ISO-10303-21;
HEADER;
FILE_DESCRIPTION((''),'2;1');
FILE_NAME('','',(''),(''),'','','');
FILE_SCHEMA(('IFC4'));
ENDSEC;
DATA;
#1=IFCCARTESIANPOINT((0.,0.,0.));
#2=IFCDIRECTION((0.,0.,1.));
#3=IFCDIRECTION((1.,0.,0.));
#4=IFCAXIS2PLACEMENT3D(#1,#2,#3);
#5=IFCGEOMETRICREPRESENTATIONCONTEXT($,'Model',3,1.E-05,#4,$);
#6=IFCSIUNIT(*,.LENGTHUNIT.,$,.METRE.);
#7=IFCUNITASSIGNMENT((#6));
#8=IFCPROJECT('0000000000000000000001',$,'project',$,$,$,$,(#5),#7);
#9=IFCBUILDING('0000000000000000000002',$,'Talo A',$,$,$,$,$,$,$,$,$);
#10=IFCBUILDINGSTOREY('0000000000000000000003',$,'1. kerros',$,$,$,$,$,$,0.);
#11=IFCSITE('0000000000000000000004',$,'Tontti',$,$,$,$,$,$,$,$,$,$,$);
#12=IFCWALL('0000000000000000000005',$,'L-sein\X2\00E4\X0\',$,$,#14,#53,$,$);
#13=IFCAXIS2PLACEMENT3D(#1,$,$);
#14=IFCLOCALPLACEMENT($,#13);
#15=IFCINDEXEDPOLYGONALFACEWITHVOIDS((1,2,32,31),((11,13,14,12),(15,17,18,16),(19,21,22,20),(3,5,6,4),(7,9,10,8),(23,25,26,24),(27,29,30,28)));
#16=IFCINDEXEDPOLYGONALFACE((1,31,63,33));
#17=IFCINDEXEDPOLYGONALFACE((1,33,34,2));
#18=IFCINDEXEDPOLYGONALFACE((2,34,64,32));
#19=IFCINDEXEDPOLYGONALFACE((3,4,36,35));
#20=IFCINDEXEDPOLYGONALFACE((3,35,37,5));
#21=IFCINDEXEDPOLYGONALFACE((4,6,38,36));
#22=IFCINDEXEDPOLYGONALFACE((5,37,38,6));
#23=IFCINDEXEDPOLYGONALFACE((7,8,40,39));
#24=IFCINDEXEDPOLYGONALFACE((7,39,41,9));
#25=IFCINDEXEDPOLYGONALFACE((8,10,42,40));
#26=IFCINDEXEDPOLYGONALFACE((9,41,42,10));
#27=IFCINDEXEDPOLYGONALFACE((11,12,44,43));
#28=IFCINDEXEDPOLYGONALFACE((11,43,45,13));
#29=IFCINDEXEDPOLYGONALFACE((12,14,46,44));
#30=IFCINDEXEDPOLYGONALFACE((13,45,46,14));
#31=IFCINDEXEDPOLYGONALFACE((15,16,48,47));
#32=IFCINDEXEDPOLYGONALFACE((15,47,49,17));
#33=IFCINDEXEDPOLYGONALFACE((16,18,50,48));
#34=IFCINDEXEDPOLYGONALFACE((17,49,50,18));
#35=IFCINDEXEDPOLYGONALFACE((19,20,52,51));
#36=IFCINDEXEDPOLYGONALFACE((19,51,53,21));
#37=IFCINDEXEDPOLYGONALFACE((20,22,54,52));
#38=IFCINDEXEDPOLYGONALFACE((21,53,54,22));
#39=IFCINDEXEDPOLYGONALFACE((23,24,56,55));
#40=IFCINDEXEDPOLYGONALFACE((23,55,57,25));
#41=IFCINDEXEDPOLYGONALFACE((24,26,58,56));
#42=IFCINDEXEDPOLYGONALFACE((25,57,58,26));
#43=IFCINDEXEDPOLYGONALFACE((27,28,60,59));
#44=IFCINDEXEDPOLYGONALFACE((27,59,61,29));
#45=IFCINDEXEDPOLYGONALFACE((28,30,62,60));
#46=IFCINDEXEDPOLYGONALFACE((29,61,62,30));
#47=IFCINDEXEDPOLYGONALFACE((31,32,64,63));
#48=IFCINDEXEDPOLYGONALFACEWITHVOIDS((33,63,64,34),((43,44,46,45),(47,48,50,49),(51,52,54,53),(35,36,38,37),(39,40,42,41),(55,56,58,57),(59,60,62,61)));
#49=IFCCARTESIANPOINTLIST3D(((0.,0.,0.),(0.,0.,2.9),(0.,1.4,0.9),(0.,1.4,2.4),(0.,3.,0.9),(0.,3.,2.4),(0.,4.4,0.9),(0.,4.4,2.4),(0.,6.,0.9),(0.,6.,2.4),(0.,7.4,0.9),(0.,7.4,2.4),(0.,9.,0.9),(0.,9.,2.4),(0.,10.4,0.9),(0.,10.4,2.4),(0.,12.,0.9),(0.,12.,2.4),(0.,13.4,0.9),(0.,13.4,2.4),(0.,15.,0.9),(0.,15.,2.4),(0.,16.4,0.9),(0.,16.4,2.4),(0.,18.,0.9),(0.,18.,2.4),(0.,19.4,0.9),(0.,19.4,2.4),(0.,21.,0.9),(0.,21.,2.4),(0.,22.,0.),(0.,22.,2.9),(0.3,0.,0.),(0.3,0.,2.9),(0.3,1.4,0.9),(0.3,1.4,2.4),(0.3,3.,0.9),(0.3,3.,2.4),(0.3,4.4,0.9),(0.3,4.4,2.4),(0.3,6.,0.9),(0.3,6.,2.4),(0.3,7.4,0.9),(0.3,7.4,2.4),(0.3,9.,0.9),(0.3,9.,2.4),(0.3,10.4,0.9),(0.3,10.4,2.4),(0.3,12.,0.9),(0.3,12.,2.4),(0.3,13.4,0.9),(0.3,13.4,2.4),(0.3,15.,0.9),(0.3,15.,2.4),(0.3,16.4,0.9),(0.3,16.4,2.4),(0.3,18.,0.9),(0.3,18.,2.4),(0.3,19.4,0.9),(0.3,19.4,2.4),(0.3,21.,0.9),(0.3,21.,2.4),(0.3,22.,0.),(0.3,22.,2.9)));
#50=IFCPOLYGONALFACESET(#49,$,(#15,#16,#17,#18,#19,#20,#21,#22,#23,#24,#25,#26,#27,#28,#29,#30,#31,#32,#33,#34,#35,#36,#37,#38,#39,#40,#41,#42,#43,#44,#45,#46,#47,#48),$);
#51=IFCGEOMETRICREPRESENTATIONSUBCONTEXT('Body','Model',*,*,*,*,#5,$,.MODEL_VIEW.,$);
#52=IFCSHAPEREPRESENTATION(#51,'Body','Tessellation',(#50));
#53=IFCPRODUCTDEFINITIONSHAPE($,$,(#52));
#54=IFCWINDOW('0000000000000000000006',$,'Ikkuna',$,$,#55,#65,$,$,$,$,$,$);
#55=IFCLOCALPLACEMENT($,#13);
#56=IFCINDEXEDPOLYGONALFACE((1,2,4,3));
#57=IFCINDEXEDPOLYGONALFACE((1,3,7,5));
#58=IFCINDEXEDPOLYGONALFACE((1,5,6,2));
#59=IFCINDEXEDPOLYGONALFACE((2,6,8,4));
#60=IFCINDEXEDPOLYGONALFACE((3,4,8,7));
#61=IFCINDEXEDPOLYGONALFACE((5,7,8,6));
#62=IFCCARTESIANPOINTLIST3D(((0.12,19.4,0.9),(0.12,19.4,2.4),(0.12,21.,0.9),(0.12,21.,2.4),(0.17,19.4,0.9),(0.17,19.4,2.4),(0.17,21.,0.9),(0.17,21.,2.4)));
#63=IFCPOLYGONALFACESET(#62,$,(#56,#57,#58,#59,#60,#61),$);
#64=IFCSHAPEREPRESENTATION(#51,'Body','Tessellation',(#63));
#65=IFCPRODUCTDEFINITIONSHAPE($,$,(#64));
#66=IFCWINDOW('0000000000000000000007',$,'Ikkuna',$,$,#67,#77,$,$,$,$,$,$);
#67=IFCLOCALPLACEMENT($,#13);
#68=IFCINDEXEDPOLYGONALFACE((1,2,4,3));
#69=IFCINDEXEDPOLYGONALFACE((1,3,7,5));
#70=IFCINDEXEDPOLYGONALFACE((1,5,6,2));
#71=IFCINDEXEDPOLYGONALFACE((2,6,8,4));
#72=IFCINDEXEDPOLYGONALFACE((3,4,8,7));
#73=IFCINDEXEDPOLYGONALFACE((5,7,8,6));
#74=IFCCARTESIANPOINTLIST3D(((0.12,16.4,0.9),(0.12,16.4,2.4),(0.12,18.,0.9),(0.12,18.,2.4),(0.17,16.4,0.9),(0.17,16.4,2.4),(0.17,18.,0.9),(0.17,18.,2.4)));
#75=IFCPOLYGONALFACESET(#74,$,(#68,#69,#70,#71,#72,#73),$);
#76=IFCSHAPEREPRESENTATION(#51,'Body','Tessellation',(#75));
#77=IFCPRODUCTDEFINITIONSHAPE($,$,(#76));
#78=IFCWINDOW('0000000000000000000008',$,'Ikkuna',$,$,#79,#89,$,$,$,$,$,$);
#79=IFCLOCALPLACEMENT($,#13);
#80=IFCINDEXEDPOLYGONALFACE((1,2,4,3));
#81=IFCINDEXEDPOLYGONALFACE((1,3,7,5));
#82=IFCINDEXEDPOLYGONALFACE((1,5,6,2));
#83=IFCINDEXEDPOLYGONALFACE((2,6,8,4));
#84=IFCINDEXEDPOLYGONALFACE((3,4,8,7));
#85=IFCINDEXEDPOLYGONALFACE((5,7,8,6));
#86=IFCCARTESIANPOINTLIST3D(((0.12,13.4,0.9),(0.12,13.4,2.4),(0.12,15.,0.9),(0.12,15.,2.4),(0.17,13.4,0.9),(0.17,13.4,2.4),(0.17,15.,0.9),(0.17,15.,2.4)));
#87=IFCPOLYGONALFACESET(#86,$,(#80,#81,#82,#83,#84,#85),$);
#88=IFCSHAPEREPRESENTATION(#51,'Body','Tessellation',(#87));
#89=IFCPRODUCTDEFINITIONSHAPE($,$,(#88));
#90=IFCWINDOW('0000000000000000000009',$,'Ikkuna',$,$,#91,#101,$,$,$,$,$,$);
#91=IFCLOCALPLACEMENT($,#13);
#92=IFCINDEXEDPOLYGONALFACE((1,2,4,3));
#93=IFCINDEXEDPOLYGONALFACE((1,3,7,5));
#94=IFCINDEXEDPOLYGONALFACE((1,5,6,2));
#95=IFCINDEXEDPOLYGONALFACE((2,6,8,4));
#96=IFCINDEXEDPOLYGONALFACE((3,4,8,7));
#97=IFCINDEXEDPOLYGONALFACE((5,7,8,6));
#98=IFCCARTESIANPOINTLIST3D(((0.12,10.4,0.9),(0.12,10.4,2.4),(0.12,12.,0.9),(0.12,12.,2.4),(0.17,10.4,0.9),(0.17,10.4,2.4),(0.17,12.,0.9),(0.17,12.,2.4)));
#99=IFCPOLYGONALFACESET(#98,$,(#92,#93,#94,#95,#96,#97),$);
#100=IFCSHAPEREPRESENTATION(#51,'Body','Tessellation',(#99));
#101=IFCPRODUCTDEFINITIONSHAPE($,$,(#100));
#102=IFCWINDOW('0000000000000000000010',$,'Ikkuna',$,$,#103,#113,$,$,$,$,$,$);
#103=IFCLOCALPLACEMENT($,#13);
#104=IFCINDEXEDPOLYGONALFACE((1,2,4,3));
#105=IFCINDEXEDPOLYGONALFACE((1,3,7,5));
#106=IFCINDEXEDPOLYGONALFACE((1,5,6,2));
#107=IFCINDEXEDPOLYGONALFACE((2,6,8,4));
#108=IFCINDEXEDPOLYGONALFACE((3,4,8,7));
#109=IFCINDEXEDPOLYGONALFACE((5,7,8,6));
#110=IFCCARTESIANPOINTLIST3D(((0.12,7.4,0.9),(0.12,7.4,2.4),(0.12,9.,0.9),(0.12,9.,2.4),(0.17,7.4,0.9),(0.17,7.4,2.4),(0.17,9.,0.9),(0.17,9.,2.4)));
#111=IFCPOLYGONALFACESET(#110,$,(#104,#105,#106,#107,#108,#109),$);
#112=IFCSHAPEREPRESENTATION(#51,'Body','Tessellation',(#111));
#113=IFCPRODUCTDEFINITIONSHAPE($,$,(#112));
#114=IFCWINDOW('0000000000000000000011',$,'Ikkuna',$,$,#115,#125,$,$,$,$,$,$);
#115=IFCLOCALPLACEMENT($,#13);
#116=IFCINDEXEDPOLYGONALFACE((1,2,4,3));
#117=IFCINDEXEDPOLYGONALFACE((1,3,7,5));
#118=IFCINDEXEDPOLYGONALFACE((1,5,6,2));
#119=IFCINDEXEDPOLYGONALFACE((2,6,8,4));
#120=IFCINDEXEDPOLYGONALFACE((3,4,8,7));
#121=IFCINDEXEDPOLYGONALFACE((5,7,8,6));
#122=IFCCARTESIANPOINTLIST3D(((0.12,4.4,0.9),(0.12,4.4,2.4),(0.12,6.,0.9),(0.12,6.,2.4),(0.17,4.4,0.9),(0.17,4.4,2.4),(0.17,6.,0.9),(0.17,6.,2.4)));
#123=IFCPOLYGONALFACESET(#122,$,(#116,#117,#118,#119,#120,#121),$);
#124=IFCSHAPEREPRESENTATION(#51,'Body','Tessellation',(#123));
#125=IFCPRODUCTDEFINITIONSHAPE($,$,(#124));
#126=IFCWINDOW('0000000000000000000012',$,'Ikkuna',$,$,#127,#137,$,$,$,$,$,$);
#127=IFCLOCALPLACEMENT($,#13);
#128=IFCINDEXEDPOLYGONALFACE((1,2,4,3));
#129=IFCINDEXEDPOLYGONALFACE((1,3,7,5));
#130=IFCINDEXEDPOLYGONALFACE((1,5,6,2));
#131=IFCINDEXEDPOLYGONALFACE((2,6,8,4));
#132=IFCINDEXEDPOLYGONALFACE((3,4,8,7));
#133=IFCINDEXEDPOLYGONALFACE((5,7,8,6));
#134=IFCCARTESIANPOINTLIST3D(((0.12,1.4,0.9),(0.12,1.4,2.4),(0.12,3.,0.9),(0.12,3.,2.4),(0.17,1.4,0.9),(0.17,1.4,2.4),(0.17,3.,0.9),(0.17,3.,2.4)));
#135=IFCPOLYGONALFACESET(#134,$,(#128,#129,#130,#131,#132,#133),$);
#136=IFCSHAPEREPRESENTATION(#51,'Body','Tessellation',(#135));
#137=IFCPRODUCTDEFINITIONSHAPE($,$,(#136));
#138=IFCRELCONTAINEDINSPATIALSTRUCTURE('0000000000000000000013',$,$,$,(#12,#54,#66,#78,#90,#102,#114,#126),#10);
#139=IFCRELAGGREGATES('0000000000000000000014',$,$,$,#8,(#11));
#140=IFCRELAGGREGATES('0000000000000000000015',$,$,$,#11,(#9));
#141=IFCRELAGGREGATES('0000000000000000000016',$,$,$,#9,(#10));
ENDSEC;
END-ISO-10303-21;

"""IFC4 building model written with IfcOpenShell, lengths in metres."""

from ifc_helpers import new_model, si_unit, frame, origin_with_axes, place, context, subcontext, project, spatial, indexed_curve, outline, extrude, element, save


model = new_model("IFC4")

# Units and contexts
model_context = context("Model", 3, precision=1e-05, world=origin_with_axes())
body_context = subcontext(model_context, "Body", "Model", "MODEL_VIEW")
ifc_project = project(units=[si_unit("LENGTHUNIT", "METRE")], contexts=[model_context])

# Site, building, storey
site = spatial("IfcSite", under=ifc_project, Name="Tontti")
building = spatial("IfcBuilding", under=site, Name="Talo A")
storey = spatial("IfcBuildingStorey", under=building, Name="1. kerros", Elevation=0.0)

# Wall, openings
wall_1_placement = place(None, frame((0.0, 22.0, 0.0), z_axis=(0.0, 0.0, 1.0), x_axis=(0.0, -1.0, 0.0)))
wall_1 = element("IfcWall", 1, at=wall_1_placement, inside=storey, Name="L-seinä", context=body_context, shape_type="SweptSolid", body=[
    extrude(outline(indexed_curve([(0.0, 0.0), (0.0, 0.3), (22.0, 0.3), (22.0, 0.0), (0.0, 0.0)], self_intersect=False)), origin_with_axes(), (0.0, 0.0, 1.0), 2.9),
])
opening_1_placement = place(wall_1_placement, frame((1.0, -0.1, 0.9), z_axis=(0.0, 0.0, 1.0), x_axis=(1.0, 0.0, 0.0)))
element("IfcOpeningElement", 2, at=opening_1_placement, cuts=wall_1, context=body_context, shape_type="SweptSolid", body=[
    extrude(outline(indexed_curve([(0.0, 0.0), (0.0, 0.5), (1.6, 0.5), (1.6, 0.0), (0.0, 0.0)], self_intersect=False)), origin_with_axes(), (0.0, 0.0, 1.0), 1.5),
])
opening_2_placement = place(wall_1_placement, frame((4.0, -0.1, 0.9), z_axis=(0.0, 0.0, 1.0), x_axis=(1.0, 0.0, 0.0)))
element("IfcOpeningElement", 3, at=opening_2_placement, cuts=wall_1, context=body_context, shape_type="SweptSolid", body=[
    extrude(outline(indexed_curve([(0.0, 0.0), (0.0, 0.5), (1.6, 0.5), (1.6, 0.0), (0.0, 0.0)], self_intersect=False)), origin_with_axes(), (0.0, 0.0, 1.0), 1.5),
])
opening_3_placement = place(wall_1_placement, frame((7.0, -0.1, 0.9), z_axis=(0.0, 0.0, 1.0), x_axis=(1.0, 0.0, 0.0)))
element("IfcOpeningElement", 4, at=opening_3_placement, cuts=wall_1, context=body_context, shape_type="SweptSolid", body=[
    extrude(outline(indexed_curve([(0.0, 0.0), (0.0, 0.5), (1.6, 0.5), (1.6, 0.0), (0.0, 0.0)], self_intersect=False)), origin_with_axes(), (0.0, 0.0, 1.0), 1.5),
])
opening_4_placement = place(wall_1_placement, frame((10.0, -0.1, 0.9), z_axis=(0.0, 0.0, 1.0), x_axis=(1.0, 0.0, 0.0)))
element("IfcOpeningElement", 5, at=opening_4_placement, cuts=wall_1, context=body_context, shape_type="SweptSolid", body=[
    extrude(outline(indexed_curve([(0.0, 0.0), (0.0, 0.5), (1.6, 0.5), (1.6, 0.0), (0.0, 0.0)], self_intersect=False)), origin_with_axes(), (0.0, 0.0, 1.0), 1.5),
])
opening_5_placement = place(wall_1_placement, frame((13.0, -0.1, 0.9), z_axis=(0.0, 0.0, 1.0), x_axis=(1.0, 0.0, 0.0)))
element("IfcOpeningElement", 6, at=opening_5_placement, cuts=wall_1, context=body_context, shape_type="SweptSolid", body=[
    extrude(outline(indexed_curve([(0.0, 0.0), (0.0, 0.5), (1.6, 0.5), (1.6, 0.0), (0.0, 0.0)], self_intersect=False)), origin_with_axes(), (0.0, 0.0, 1.0), 1.5),
])
opening_6_placement = place(wall_1_placement, frame((16.0, -0.1, 0.9), z_axis=(0.0, 0.0, 1.0), x_axis=(1.0, 0.0, 0.0)))
element("IfcOpeningElement", 7, at=opening_6_placement, cuts=wall_1, context=body_context, shape_type="SweptSolid", body=[
    extrude(outline(indexed_curve([(0.0, 0.0), (0.0, 0.5), (1.6, 0.5), (1.6, 0.0), (0.0, 0.0)], self_intersect=False)), origin_with_axes(), (0.0, 0.0, 1.0), 1.5),
])
opening_7_placement = place(wall_1_placement, frame((19.0, -0.1, 0.9), z_axis=(0.0, 0.0, 1.0), x_axis=(1.0, 0.0, 0.0)))
element("IfcOpeningElement", 8, at=opening_7_placement, cuts=wall_1, context=body_context, shape_type="SweptSolid", body=[
    extrude(outline(indexed_curve([(0.0, 0.0), (0.0, 0.5), (1.6, 0.5), (1.6, 0.0), (0.0, 0.0)], self_intersect=False)), origin_with_axes(), (0.0, 0.0, 1.0), 1.5),
])

# Windows
for number, where, z_axis, x_axis, name in (
    (9, (0.12, 21.0, 0.9), (0.0, 0.0, 1.0), (0.0, -1.0, 0.0), "Ikkuna"),
    (10, (0.12, 18.0, 0.9), (0.0, 0.0, 1.0), (0.0, -1.0, 0.0), "Ikkuna"),
    (11, (0.12, 15.0, 0.9), (0.0, 0.0, 1.0), (0.0, -1.0, 0.0), "Ikkuna"),
    (12, (0.12, 12.0, 0.9), (0.0, 0.0, 1.0), (0.0, -1.0, 0.0), "Ikkuna"),
    (13, (0.12, 9.0, 0.9), (0.0, 0.0, 1.0), (0.0, -1.0, 0.0), "Ikkuna"),
    (14, (0.12, 6.0, 0.9), (0.0, 0.0, 1.0), (0.0, -1.0, 0.0), "Ikkuna"),
    (15, (0.12, 3.0, 0.9), (0.0, 0.0, 1.0), (0.0, -1.0, 0.0), "Ikkuna"),
):
    element("IfcWindow", number, at=place(None, frame(where, z_axis=z_axis, x_axis=x_axis)), inside=storey, Name=name, context=body_context, shape_type="SweptSolid", body=[
        extrude(outline(indexed_curve([(0.0, 0.0), (0.0, 0.05), (1.6, 0.05), (1.6, 0.0), (0.0, 0.0)], self_intersect=False)), origin_with_axes(), (0.0, 0.0, 1.0), 1.5),
    ])

save(model, "model.ifc")
